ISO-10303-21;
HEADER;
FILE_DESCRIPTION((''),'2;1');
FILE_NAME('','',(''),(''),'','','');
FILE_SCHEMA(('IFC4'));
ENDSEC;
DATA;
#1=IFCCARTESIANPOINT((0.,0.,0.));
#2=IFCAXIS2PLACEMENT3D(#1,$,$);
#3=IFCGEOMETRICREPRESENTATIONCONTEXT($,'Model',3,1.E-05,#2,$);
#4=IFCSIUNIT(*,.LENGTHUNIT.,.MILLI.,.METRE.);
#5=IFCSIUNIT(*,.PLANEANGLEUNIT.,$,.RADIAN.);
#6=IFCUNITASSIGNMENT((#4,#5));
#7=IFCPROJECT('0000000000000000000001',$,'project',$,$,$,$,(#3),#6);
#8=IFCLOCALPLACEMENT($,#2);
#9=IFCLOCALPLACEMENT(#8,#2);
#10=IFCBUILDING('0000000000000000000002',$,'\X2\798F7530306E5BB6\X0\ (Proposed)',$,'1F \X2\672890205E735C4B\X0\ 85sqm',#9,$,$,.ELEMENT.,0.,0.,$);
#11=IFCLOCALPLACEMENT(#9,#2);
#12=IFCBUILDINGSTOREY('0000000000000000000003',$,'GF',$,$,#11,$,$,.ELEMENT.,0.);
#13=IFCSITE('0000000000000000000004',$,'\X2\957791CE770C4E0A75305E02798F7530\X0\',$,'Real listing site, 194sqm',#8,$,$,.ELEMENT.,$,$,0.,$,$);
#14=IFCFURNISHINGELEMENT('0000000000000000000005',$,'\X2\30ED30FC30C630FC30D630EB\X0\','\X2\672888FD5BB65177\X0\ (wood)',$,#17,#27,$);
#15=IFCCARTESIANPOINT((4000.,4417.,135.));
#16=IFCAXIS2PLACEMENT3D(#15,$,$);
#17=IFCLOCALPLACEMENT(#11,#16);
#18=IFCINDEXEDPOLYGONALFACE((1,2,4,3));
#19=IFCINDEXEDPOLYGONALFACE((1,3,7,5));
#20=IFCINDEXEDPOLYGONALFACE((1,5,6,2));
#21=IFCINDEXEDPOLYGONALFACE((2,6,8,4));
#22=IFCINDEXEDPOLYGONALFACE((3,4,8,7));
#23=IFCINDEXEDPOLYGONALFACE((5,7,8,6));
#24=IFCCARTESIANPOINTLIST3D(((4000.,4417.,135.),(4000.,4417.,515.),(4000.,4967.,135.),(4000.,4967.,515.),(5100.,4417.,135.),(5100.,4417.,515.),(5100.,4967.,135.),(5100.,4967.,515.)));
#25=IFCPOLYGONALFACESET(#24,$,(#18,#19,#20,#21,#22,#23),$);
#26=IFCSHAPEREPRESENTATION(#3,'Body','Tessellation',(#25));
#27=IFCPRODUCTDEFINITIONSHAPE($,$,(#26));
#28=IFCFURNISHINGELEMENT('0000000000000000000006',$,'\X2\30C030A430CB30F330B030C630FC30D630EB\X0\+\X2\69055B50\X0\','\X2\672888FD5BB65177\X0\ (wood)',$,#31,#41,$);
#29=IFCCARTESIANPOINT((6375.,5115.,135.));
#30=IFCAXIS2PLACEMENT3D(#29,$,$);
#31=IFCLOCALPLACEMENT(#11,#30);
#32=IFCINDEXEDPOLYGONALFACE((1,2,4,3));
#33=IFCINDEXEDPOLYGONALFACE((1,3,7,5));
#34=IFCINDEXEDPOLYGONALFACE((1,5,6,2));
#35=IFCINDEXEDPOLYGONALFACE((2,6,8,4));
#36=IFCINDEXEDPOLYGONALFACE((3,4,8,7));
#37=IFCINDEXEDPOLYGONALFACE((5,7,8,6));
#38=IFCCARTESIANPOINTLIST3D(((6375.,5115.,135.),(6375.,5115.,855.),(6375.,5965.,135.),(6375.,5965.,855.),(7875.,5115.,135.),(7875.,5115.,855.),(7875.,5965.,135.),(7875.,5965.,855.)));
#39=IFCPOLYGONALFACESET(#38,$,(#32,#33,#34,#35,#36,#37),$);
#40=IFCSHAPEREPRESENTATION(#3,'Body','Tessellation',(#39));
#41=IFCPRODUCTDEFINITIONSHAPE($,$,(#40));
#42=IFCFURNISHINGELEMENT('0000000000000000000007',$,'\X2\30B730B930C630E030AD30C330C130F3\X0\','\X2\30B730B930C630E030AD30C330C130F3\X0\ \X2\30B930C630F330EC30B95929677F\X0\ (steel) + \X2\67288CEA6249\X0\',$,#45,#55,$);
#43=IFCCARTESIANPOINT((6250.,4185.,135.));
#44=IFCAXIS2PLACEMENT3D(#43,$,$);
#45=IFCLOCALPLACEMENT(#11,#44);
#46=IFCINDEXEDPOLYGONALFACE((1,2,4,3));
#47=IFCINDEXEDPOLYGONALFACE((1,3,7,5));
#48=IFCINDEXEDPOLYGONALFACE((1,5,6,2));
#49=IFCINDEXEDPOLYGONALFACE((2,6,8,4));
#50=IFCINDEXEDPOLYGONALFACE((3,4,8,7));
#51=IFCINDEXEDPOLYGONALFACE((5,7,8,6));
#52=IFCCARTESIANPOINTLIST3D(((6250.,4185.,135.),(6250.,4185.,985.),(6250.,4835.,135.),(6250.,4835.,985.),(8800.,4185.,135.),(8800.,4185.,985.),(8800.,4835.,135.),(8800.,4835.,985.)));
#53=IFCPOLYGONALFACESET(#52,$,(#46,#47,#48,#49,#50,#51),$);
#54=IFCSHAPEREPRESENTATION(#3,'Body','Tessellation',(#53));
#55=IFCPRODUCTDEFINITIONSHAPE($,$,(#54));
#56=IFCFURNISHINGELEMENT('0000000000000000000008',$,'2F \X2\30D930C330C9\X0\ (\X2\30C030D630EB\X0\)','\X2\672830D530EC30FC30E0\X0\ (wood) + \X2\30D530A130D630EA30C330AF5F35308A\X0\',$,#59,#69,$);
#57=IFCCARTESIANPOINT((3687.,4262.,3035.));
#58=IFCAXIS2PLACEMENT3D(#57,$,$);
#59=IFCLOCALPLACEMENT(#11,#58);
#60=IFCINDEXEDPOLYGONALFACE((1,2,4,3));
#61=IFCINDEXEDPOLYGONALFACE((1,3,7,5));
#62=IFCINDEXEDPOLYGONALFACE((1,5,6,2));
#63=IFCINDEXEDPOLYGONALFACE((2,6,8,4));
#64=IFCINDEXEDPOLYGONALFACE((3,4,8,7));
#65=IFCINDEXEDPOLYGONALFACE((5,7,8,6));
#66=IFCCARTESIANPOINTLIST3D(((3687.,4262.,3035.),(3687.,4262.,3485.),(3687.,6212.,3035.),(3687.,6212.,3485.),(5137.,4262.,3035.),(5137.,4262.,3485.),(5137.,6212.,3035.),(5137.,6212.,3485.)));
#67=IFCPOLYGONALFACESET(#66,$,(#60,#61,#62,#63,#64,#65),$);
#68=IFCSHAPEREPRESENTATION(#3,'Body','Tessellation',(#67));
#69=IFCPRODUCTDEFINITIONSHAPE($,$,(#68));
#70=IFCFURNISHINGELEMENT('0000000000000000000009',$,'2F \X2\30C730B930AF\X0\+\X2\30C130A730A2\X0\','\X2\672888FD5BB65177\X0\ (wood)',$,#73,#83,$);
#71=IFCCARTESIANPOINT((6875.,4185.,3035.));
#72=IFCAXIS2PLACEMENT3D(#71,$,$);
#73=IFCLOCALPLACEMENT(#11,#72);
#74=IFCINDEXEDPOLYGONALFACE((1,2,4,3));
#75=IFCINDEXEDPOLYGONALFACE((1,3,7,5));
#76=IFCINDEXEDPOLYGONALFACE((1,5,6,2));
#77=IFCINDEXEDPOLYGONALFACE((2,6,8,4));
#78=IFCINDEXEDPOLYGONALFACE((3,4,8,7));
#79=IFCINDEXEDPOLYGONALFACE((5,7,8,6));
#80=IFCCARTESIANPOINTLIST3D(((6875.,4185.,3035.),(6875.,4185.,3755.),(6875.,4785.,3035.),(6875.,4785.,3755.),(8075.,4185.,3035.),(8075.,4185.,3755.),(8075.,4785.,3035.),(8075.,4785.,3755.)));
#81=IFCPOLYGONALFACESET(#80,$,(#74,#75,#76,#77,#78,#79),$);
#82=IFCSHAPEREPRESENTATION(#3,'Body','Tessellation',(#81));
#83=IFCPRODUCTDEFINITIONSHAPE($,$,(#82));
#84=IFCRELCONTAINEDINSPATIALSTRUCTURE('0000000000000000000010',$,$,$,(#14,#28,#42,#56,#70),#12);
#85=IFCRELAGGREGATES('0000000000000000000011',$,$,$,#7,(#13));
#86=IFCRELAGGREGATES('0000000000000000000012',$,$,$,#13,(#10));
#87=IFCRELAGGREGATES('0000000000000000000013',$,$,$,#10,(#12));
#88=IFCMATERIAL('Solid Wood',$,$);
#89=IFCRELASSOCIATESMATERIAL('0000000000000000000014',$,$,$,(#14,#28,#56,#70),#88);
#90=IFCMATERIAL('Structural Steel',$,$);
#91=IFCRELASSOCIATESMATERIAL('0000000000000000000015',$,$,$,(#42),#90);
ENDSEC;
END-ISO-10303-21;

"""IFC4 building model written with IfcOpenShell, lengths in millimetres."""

from ifc_helpers import new_model, si_unit, frame, frame_2d, origin, place, context, project, spatial, rectangle, extrude, material, element, save


model = new_model("IFC4")

# Units and contexts
model_context = context("Model", 3, precision=1e-05, world=origin())
ifc_project = project(units=[si_unit("LENGTHUNIT", "METRE", prefix="MILLI"), si_unit("PLANEANGLEUNIT", "RADIAN")], contexts=[model_context])

# Site, building, storey
site_placement = place(None, origin())
site = spatial("IfcSite", under=ifc_project, at=site_placement, Name="長野県上田市福田", ObjectType="Real listing site, 194sqm", CompositionType="ELEMENT", RefElevation=0.0)
building_placement = place(site_placement, origin())
building = spatial("IfcBuilding", under=site, at=building_placement, Name="福田の家 (Proposed)", ObjectType="1F 木造平屋 85sqm", CompositionType="ELEMENT", ElevationOfRefHeight=0.0, ElevationOfTerrain=0.0)
storey_placement = place(building_placement, origin())
storey = spatial("IfcBuildingStorey", under=building, at=storey_placement, Name="GF", CompositionType="ELEMENT", Elevation=0.0)

# Shared definitions
ifc_material_1 = material(Name="Solid Wood")

# Shared definitions
ifc_material_2 = material(Name="Structural Steel")

# Furnishing elements
furnishing_1_placement = place(storey_placement, frame((4000.0, 4417.0, 135.0)))
element("IfcFurnishingElement", 1, at=furnishing_1_placement, inside=storey, material=ifc_material_1, Name="ローテーブル", Description="木製家具 (wood)", context=model_context, shape_type="SweptSolid", body=[
    extrude(rectangle(XDim=1100.0, YDim=550.0, at=frame_2d((550.0, 275.0))), frame((4000.0, 4417.0, 135.0)), (0.0, 0.0, 1.0), 380.0),
])
furnishing_2_placement = place(storey_placement, frame((6375.0, 5115.0, 135.0)))
element("IfcFurnishingElement", 2, at=furnishing_2_placement, inside=storey, material=ifc_material_1, Name="ダイニングテーブル+椅子", Description="木製家具 (wood)", context=model_context, shape_type="SweptSolid", body=[
    extrude(rectangle(XDim=1500.0, YDim=850.0, at=frame_2d((750.0, 425.0))), frame((6375.0, 5115.0, 135.0)), (0.0, 0.0, 1.0), 720.0),
])
furnishing_3_placement = place(storey_placement, frame((6250.0, 4185.0, 135.0)))
element("IfcFurnishingElement", 3, at=furnishing_3_placement, inside=storey, material=ifc_material_2, Name="システムキッチン", Description="システムキッチン ステンレス天板 (steel) + 木質扉", context=model_context, shape_type="SweptSolid", body=[
    extrude(rectangle(XDim=2550.0, YDim=650.0, at=frame_2d((1275.0, 325.0))), frame((6250.0, 4185.0, 135.0)), (0.0, 0.0, 1.0), 850.0),
])
furnishing_4_placement = place(storey_placement, frame((3687.0, 4262.0, 3035.0)))
element("IfcFurnishingElement", 4, at=furnishing_4_placement, inside=storey, material=ifc_material_1, Name="2F ベッド (ダブル)", Description="木フレーム (wood) + ファブリック張り", context=model_context, shape_type="SweptSolid", body=[
    extrude(rectangle(XDim=1450.0, YDim=1950.0, at=frame_2d((725.0, 975.0))), frame((3687.0, 4262.0, 3035.0)), (0.0, 0.0, 1.0), 450.0),
])
furnishing_5_placement = place(storey_placement, frame((6875.0, 4185.0, 3035.0)))
element("IfcFurnishingElement", 5, at=furnishing_5_placement, inside=storey, material=ifc_material_1, Name="2F デスク+チェア", Description="木製家具 (wood)", context=model_context, shape_type="SweptSolid", body=[
    extrude(rectangle(XDim=1200.0, YDim=600.0, at=frame_2d((600.0, 300.0))), frame((6875.0, 4185.0, 3035.0)), (0.0, 0.0, 1.0), 720.0),
])

save(model, "model.ifc")
